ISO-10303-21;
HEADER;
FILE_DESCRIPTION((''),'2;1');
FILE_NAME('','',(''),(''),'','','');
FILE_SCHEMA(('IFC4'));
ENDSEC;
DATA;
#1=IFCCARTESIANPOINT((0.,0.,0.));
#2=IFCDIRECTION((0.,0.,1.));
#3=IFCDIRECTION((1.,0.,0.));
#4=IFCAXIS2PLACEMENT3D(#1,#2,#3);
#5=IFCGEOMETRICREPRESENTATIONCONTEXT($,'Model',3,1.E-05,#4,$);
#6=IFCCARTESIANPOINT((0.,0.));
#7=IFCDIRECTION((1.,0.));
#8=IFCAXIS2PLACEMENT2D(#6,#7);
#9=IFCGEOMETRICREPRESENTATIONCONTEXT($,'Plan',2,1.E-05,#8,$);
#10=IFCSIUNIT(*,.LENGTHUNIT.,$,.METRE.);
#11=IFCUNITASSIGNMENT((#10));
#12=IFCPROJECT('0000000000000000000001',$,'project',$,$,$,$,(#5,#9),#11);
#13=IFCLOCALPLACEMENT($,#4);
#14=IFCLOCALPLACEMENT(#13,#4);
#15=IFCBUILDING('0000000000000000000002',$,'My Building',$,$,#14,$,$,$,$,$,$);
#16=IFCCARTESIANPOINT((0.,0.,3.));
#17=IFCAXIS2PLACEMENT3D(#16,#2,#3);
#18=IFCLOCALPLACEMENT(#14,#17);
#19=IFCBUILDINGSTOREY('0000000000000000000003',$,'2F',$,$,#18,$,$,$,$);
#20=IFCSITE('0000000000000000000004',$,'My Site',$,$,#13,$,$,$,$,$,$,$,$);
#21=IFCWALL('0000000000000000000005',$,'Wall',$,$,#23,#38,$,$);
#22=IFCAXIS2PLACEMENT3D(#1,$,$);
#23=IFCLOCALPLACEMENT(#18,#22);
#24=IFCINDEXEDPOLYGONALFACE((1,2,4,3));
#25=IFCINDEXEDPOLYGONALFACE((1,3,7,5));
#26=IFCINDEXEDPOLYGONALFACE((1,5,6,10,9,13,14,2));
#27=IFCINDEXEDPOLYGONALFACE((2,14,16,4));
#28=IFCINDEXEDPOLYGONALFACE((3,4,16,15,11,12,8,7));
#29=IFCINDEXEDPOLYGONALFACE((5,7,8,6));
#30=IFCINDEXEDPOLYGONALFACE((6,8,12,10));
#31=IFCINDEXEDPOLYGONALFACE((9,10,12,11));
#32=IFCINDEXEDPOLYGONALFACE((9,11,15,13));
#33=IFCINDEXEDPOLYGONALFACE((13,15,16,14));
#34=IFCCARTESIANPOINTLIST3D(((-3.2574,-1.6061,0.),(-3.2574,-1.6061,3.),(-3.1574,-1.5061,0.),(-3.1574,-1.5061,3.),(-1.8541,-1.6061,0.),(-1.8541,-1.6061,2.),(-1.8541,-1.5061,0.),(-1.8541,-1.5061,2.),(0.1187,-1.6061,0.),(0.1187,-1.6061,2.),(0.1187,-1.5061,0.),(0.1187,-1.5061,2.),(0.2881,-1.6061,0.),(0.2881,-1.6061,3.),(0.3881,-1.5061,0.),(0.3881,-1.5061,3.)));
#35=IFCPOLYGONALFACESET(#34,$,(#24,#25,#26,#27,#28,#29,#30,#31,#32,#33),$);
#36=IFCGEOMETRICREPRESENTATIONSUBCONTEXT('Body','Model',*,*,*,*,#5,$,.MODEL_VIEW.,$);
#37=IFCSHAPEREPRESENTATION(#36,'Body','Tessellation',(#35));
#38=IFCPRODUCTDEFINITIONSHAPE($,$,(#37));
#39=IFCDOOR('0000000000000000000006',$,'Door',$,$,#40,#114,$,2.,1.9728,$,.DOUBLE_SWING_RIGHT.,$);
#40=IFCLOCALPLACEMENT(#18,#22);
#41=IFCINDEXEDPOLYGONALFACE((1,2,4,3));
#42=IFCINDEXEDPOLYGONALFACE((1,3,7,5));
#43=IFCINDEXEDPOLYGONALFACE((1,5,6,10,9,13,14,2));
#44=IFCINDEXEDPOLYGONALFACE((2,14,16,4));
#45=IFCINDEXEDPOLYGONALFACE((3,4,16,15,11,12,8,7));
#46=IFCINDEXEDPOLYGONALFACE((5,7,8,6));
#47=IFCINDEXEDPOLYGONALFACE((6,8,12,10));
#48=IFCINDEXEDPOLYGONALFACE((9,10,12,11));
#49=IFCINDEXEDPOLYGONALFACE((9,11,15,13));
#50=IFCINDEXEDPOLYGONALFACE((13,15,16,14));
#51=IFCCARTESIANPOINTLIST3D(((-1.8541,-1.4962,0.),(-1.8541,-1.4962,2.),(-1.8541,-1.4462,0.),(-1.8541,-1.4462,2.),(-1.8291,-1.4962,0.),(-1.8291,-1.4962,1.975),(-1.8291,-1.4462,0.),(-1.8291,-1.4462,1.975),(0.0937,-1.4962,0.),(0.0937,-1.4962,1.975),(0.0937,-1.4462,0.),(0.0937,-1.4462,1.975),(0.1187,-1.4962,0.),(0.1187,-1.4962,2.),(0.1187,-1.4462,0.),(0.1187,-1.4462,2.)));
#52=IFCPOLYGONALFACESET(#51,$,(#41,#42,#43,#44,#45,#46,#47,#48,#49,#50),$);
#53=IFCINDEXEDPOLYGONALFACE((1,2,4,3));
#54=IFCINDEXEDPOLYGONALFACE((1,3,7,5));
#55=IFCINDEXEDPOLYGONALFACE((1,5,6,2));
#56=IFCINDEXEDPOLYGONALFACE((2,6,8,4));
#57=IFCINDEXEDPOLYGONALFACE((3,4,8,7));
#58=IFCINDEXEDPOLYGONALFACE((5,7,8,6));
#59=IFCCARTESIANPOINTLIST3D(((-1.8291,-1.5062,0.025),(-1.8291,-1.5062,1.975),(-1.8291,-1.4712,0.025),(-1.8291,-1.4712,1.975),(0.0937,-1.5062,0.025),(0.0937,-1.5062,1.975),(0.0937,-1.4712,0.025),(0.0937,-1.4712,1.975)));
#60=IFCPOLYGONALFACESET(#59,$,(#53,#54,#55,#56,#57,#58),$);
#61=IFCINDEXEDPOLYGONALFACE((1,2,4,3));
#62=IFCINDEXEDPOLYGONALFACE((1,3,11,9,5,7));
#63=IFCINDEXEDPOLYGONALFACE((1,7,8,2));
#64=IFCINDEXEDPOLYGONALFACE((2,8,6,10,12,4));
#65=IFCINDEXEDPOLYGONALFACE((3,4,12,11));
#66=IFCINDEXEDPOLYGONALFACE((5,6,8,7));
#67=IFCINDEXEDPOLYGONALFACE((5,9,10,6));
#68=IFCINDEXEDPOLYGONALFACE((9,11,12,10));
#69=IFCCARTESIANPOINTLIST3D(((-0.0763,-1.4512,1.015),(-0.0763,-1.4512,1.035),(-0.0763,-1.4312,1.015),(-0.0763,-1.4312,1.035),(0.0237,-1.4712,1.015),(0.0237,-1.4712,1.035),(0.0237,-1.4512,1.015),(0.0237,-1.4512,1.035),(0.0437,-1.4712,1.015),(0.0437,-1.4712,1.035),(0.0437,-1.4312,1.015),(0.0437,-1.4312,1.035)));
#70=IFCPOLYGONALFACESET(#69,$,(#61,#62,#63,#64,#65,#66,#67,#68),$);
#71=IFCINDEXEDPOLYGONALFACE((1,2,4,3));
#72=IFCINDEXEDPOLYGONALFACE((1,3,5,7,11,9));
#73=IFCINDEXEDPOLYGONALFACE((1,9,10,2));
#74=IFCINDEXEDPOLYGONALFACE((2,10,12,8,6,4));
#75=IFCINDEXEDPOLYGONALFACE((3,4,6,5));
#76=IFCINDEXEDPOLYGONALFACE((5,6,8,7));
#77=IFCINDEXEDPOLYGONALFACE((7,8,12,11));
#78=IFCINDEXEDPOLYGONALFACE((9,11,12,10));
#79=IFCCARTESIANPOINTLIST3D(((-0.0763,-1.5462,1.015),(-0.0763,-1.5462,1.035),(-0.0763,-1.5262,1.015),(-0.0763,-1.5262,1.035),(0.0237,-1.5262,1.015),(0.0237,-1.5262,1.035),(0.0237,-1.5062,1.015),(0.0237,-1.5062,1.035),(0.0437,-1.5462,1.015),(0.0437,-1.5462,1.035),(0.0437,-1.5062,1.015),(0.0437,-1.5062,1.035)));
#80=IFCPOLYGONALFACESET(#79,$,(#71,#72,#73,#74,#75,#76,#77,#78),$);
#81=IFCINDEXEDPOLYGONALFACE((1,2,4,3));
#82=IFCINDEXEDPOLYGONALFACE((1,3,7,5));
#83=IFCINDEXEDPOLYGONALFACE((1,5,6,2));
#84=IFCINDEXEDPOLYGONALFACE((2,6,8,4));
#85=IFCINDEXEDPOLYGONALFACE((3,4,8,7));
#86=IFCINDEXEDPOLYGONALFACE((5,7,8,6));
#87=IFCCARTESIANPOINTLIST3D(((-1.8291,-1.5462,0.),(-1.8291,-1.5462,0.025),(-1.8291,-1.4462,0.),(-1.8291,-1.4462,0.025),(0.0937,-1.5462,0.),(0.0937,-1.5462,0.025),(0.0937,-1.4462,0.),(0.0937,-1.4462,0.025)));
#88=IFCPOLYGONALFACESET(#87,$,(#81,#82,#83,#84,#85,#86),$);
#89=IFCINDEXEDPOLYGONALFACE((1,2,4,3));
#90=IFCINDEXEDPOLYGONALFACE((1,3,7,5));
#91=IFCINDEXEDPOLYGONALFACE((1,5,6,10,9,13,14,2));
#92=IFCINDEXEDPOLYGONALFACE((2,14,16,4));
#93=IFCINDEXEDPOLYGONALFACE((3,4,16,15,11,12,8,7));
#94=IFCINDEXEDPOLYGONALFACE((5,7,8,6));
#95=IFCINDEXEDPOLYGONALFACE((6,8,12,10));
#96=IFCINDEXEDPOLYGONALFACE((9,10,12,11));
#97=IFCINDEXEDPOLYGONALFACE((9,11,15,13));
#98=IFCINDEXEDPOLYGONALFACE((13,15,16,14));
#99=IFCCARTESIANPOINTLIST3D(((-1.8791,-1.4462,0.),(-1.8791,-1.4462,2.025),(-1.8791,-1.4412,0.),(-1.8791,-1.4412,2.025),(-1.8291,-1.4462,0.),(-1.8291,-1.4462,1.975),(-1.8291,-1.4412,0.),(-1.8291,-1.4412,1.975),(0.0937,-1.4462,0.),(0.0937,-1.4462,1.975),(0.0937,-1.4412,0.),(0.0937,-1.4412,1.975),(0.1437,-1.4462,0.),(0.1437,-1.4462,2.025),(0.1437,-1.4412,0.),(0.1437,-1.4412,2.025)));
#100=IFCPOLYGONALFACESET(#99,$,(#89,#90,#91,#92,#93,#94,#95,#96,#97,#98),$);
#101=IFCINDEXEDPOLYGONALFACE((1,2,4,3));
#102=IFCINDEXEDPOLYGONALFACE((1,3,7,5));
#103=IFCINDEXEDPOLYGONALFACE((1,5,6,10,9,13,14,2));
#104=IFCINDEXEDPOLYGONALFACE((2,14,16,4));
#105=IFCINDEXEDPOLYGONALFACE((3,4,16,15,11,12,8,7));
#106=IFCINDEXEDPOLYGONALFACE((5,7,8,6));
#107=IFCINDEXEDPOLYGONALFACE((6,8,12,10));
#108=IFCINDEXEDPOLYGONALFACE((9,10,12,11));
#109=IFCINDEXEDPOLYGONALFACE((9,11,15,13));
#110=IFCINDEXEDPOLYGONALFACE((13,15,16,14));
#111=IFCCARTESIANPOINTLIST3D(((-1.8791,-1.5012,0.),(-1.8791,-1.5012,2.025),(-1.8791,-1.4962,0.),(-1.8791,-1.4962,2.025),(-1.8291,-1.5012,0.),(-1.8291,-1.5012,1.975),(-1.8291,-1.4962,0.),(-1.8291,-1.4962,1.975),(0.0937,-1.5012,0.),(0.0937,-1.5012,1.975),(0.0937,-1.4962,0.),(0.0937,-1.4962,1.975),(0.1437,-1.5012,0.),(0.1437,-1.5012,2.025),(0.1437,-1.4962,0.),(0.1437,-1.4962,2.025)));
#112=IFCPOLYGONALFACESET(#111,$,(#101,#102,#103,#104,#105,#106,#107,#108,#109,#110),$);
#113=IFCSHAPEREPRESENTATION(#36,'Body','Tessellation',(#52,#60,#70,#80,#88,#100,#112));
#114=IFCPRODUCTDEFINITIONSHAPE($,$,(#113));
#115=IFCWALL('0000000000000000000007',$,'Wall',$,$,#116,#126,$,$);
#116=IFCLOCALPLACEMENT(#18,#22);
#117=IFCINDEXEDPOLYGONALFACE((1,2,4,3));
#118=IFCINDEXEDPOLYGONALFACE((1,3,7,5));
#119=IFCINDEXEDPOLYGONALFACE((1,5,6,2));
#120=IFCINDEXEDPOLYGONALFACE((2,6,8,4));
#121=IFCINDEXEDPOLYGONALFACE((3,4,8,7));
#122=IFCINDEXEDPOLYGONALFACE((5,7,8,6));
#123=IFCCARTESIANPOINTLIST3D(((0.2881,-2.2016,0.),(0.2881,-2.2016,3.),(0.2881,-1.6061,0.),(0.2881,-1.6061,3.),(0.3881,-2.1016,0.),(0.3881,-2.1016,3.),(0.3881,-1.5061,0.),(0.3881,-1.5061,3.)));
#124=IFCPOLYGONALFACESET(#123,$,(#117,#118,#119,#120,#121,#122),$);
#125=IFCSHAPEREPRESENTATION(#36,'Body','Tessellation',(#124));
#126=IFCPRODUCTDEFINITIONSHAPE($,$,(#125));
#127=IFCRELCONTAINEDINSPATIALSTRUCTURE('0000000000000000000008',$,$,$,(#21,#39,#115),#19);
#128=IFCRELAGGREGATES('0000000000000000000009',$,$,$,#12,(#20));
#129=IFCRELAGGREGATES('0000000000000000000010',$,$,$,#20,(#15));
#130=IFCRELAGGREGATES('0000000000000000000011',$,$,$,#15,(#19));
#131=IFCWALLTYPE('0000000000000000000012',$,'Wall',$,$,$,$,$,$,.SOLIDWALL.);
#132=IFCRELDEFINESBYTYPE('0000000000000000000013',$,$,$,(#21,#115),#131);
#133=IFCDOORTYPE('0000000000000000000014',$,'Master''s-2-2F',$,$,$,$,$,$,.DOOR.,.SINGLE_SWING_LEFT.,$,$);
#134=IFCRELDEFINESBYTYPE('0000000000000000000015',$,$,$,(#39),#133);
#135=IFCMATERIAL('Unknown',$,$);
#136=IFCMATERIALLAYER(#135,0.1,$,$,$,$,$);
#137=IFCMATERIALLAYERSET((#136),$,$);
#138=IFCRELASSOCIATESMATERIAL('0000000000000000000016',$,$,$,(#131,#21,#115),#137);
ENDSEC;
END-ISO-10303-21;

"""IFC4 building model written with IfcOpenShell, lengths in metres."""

from ifc_helpers import new_model, entity, si_unit, frame, origin_with_axes, origin_2d_with_axis, place, context, subcontext, project, spatial, line, indexed_curve, outline, extrude, shape, source, transform, mapped, material, layer, layer_set, layer_usage, type_object, type_shapes, element, fill, save


model = new_model("IFC4")

# Units and contexts
model_context = context("Model", 3, precision=1e-05, world=origin_with_axes())
plan_context = context("Plan", 2, precision=1e-05, world=origin_2d_with_axis())
body_context_1 = subcontext(model_context, "Body", "Model", "MODEL_VIEW")
body_context_2 = subcontext(plan_context, "Body", "Plan", "PLAN_VIEW")
ifc_project = project(units=[si_unit("LENGTHUNIT", "METRE")], contexts=[model_context, plan_context])

# Site, building, storey
site_placement = place(None, origin_with_axes())
site = spatial("IfcSite", under=ifc_project, at=site_placement, Name="My Site")
building_placement = place(site_placement, origin_with_axes())
building = spatial("IfcBuilding", under=site, at=building_placement, Name="My Building")
storey_placement = place(building_placement, frame((0.0, 0.0, 3.0), z_axis=(0.0, 0.0, 1.0), x_axis=(1.0, 0.0, 0.0)))
storey = spatial("IfcBuildingStorey", under=building, at=storey_placement, Name="2F")

# Shared definitions
ifc_material = material(Name="Unknown")

# Shared definitions
ifc_layer_1 = layer(ifc_material, 0.1)
ifc_layer_set_1 = layer_set([ifc_layer_1])
wall_type = type_object("IfcWallType", Name="Wall", PredefinedType="SOLIDWALL", material=ifc_layer_set_1)

# Wall, opening, door
ifc_layer_usage_1 = layer_usage(ifc_layer_set_1, "AXIS2", "POSITIVE", 0.0)
wall_1_placement = place(storey_placement, frame((-3.2574, -1.6061, 0.0), z_axis=(0.0, 0.0, 1.0), x_axis=(1.0, 0.0, 0.0)))
wall_1 = element("IfcWall", 1, at=wall_1_placement, inside=storey, type_object=wall_type, material=ifc_layer_usage_1, Name="Wall", context=body_context_1, shape_type="SweptSolid", body=[
    extrude(outline(indexed_curve([(0.0, 0.0), (0.1, 0.1), (3.6455, 0.1), (3.5455, 0.0)], segments=[line(1, 2, 3, 4, 1)])), origin_with_axes(), (0.0, 0.0, 1.0), 3.0),
])
shared_shape_1 = source(origin_with_axes(), body_context_1, "Body", "SweptSolid", [
    extrude(outline(indexed_curve([(0.0, 0.0), (1.9728, 0.0), (1.9728, 2.0), (0.0, 2.0)], segments=[line(1, 2, 3, 4, 1)])), frame((0.0, -0.6, 0.0), z_axis=(0.0, -1.0, 0.0), x_axis=(1.0, 0.0, 0.0)), (0.0, 0.0, -1.0), 1.2),
])
opening_1_placement = place(wall_1_placement, frame((3.376, 0.16, 0.0), z_axis=(0.0, 0.0, 1.0), x_axis=(-1.0, 0.000003, 0.0)))
opening_1 = element("IfcOpeningElement", 2, at=opening_1_placement, cuts=wall_1, PredefinedType="OPENING", context=body_context_1, shape_type="MappedRepresentation", body=[
    mapped(shared_shape_1, transform((0.0, 0.0, 0.0), x_axis=(1.0, 0.0, 0.0), y_axis=(0.0, 1.0, 0.0), z_axis=(0.0, 0.0, 1.0), scale=1.0)),
])
door_type_1 = type_object("IfcDoorType", Name="Master's-2-2F", OperationType="SINGLE_SWING_LEFT", PredefinedType="DOOR")
shared_shape_2 = source(origin_with_axes(), body_context_1, "Body", "SweptSolid", [
    extrude(outline(indexed_curve([(0.0, 0.0), (0.0, 2.0), (1.9728, 2.0), (1.9728, 0.0), (1.9478, 0.0), (1.9478, 1.975), (0.025, 1.975), (0.025, 0.0)], segments=[line(1, 2, 3, 4, 5, 6, 7, 8, 1)])), frame((0.0, 0.0, 0.0), z_axis=(0.0, -1.0, 0.0), x_axis=(1.0, 0.0, 0.0)), (0.0, 0.0, -1.0), 0.05),
    extrude(outline(indexed_curve([(0.0, 0.0), (1.9228, 0.0), (1.9228, 0.035), (0.0, 0.035)], segments=[line(1, 2, 3, 4, 1)])), frame((0.025, 0.025, 0.025), z_axis=(0.0, 0.0, 1.0), x_axis=(1.0, 0.0, 0.0)), (0.0, 0.0, 1.0), 1.95),
    extrude(outline(indexed_curve([(0.0, 0.0), (0.0, -0.04), (0.12, -0.04), (0.12, -0.02), (0.02, -0.02), (0.02, 0.0)], segments=[line(1, 2, 3, 4, 5, 6, 1)])), frame((0.075, 0.025, 1.015), z_axis=(0.0, 0.0, 1.0), x_axis=(1.0, 0.0, 0.0)), (0.0, 0.0, 1.0), 0.02),
    extrude(outline(indexed_curve([(0.0, 0.0), (0.0, 0.04), (0.12, 0.04), (0.12, 0.02), (0.02, 0.02), (0.02, 0.0)], segments=[line(1, 2, 3, 4, 5, 6, 1)])), frame((0.075, 0.06, 1.015), z_axis=(0.0, 0.0, 1.0), x_axis=(1.0, 0.0, 0.0)), (0.0, 0.0, 1.0), 0.02),
    extrude(outline(indexed_curve([(0.0, 0.0), (1.9228, 0.0), (1.9228, 0.1), (0.0, 0.1)], segments=[line(1, 2, 3, 4, 1)])), frame((0.025, 0.0, 0.0), z_axis=(0.0, 0.0, 1.0), x_axis=(1.0, 0.0, 0.0)), (0.0, 0.0, 1.0), 0.025),
    extrude(outline(indexed_curve([(0.0, 0.0), (0.0, 2.025), (2.0228, 2.025), (2.0228, 0.0), (1.9728, 0.0), (1.9728, 1.975), (0.05, 1.975), (0.05, 0.0)], segments=[line(1, 2, 3, 4, 5, 6, 7, 8, 1)])), frame((-0.025, -0.005, 0.0), z_axis=(0.0, -1.0, 0.0), x_axis=(1.0, 0.0, 0.0)), (0.0, 0.0, -1.0), 0.005),
    extrude(outline(indexed_curve([(0.0, 0.0), (0.0, 2.025), (2.0228, 2.025), (2.0228, 0.0), (1.9728, 0.0), (1.9728, 1.975), (0.05, 1.975), (0.05, 0.0)], segments=[line(1, 2, 3, 4, 5, 6, 7, 8, 1)])), frame((-0.025, 0.05, 0.0), z_axis=(0.0, -1.0, 0.0), x_axis=(1.0, 0.0, 0.0)), (0.0, 0.0, -1.0), 0.005),
])
shared_shape_3 = source(origin_with_axes(), body_context_2, "Body", "Curve2D", [
    entity("IfcIndexedPolyCurve", entity("IfcCartesianPointList2D", [[0.0, 0.0], [0.025, 0.0], [0.025, 0.05], [0.0, 0.05]]), [entity("IfcLineIndex", [1, 2, 3, 4, 1])]),
    entity("IfcIndexedPolyCurve", entity("IfcCartesianPointList2D", [[1.9728, 0.0], [1.9478, 0.0], [1.9478, 0.05], [1.9728, 0.05]]), [entity("IfcLineIndex", [1, 2, 3, 4, 1])]),
    entity("IfcIndexedPolyCurve", entity("IfcCartesianPointList2D", [[1.9478, 0.05], [1.9478, -1.8728], [1.9128, -1.8728]])),
    entity("IfcTrimmedCurve", entity("IfcEllipse", entity("IfcAxis2Placement2D", entity("IfcCartesianPoint", [1.9128, 0.05]), entity("IfcDirection", [1.0, 0.0])), 1.8878, 1.9228), [entity("IfcCartesianPoint", [1.9128, 1.9728])], [entity("IfcCartesianPoint", [1.9128, -1.8728])], True, "CARTESIAN"),
    entity("IfcIndexedPolyCurve", entity("IfcCartesianPointList2D", [[1.9478, 0.05], [1.9128, 0.05], [1.9128, 1.9728], [1.9478, 1.9728]]), [entity("IfcLineIndex", [1, 2, 3, 4, 1])]),
])
type_shapes(door_type_1, [shared_shape_2, shared_shape_3])
door_1_placement = place(opening_1_placement, frame((0.0, 0.0, 0.0), z_axis=(0.0, 0.0, 1.0), x_axis=(1.0, 0.0, 0.0)))
door_1 = element("IfcDoor", 3, at=door_1_placement, inside=storey, type_object=door_type_1, Name="Door", OperationType="DOUBLE_SWING_RIGHT", OverallHeight=2.0, OverallWidth=1.9728, shapes=[
    shape(body_context_1, "Body", "MappedRepresentation", [mapped(shared_shape_2, transform((0.0, 0.0, 0.0), x_axis=(1.0, 0.0, 0.0), y_axis=(0.0, 1.0, 0.0), z_axis=(0.0, 0.0, 1.0), scale=1.0))]),
    shape(body_context_2, "Body", "MappedRepresentation", [mapped(shared_shape_3, transform((0.0, 0.0, 0.0), x_axis=(1.0, 0.0, 0.0), y_axis=(0.0, 1.0, 0.0), z_axis=(0.0, 0.0, 1.0), scale=1.0))]),
])
fill(opening_1, door_1)

# Wall
ifc_layer_usage_2 = layer_usage(ifc_layer_set_1, "AXIS2", "POSITIVE", 0.0)
wall_2_placement = place(storey_placement, frame((0.2881, -1.6061, 0.0), z_axis=(0.0, 0.0, 1.0), x_axis=(0.0, -1.0, 0.0)))
element("IfcWall", 4, at=wall_2_placement, inside=storey, type_object=wall_type, material=ifc_layer_usage_2, Name="Wall", context=body_context_1, shape_type="SweptSolid", body=[
    extrude(outline(indexed_curve([(0.0, 0.0), (-0.1, 0.1), (0.4955, 0.1), (0.5955, 0.0)], segments=[line(1, 2, 3, 4, 1)])), origin_with_axes(), (0.0, 0.0, 1.0), 3.0),
])

save(model, "model.ifc")
